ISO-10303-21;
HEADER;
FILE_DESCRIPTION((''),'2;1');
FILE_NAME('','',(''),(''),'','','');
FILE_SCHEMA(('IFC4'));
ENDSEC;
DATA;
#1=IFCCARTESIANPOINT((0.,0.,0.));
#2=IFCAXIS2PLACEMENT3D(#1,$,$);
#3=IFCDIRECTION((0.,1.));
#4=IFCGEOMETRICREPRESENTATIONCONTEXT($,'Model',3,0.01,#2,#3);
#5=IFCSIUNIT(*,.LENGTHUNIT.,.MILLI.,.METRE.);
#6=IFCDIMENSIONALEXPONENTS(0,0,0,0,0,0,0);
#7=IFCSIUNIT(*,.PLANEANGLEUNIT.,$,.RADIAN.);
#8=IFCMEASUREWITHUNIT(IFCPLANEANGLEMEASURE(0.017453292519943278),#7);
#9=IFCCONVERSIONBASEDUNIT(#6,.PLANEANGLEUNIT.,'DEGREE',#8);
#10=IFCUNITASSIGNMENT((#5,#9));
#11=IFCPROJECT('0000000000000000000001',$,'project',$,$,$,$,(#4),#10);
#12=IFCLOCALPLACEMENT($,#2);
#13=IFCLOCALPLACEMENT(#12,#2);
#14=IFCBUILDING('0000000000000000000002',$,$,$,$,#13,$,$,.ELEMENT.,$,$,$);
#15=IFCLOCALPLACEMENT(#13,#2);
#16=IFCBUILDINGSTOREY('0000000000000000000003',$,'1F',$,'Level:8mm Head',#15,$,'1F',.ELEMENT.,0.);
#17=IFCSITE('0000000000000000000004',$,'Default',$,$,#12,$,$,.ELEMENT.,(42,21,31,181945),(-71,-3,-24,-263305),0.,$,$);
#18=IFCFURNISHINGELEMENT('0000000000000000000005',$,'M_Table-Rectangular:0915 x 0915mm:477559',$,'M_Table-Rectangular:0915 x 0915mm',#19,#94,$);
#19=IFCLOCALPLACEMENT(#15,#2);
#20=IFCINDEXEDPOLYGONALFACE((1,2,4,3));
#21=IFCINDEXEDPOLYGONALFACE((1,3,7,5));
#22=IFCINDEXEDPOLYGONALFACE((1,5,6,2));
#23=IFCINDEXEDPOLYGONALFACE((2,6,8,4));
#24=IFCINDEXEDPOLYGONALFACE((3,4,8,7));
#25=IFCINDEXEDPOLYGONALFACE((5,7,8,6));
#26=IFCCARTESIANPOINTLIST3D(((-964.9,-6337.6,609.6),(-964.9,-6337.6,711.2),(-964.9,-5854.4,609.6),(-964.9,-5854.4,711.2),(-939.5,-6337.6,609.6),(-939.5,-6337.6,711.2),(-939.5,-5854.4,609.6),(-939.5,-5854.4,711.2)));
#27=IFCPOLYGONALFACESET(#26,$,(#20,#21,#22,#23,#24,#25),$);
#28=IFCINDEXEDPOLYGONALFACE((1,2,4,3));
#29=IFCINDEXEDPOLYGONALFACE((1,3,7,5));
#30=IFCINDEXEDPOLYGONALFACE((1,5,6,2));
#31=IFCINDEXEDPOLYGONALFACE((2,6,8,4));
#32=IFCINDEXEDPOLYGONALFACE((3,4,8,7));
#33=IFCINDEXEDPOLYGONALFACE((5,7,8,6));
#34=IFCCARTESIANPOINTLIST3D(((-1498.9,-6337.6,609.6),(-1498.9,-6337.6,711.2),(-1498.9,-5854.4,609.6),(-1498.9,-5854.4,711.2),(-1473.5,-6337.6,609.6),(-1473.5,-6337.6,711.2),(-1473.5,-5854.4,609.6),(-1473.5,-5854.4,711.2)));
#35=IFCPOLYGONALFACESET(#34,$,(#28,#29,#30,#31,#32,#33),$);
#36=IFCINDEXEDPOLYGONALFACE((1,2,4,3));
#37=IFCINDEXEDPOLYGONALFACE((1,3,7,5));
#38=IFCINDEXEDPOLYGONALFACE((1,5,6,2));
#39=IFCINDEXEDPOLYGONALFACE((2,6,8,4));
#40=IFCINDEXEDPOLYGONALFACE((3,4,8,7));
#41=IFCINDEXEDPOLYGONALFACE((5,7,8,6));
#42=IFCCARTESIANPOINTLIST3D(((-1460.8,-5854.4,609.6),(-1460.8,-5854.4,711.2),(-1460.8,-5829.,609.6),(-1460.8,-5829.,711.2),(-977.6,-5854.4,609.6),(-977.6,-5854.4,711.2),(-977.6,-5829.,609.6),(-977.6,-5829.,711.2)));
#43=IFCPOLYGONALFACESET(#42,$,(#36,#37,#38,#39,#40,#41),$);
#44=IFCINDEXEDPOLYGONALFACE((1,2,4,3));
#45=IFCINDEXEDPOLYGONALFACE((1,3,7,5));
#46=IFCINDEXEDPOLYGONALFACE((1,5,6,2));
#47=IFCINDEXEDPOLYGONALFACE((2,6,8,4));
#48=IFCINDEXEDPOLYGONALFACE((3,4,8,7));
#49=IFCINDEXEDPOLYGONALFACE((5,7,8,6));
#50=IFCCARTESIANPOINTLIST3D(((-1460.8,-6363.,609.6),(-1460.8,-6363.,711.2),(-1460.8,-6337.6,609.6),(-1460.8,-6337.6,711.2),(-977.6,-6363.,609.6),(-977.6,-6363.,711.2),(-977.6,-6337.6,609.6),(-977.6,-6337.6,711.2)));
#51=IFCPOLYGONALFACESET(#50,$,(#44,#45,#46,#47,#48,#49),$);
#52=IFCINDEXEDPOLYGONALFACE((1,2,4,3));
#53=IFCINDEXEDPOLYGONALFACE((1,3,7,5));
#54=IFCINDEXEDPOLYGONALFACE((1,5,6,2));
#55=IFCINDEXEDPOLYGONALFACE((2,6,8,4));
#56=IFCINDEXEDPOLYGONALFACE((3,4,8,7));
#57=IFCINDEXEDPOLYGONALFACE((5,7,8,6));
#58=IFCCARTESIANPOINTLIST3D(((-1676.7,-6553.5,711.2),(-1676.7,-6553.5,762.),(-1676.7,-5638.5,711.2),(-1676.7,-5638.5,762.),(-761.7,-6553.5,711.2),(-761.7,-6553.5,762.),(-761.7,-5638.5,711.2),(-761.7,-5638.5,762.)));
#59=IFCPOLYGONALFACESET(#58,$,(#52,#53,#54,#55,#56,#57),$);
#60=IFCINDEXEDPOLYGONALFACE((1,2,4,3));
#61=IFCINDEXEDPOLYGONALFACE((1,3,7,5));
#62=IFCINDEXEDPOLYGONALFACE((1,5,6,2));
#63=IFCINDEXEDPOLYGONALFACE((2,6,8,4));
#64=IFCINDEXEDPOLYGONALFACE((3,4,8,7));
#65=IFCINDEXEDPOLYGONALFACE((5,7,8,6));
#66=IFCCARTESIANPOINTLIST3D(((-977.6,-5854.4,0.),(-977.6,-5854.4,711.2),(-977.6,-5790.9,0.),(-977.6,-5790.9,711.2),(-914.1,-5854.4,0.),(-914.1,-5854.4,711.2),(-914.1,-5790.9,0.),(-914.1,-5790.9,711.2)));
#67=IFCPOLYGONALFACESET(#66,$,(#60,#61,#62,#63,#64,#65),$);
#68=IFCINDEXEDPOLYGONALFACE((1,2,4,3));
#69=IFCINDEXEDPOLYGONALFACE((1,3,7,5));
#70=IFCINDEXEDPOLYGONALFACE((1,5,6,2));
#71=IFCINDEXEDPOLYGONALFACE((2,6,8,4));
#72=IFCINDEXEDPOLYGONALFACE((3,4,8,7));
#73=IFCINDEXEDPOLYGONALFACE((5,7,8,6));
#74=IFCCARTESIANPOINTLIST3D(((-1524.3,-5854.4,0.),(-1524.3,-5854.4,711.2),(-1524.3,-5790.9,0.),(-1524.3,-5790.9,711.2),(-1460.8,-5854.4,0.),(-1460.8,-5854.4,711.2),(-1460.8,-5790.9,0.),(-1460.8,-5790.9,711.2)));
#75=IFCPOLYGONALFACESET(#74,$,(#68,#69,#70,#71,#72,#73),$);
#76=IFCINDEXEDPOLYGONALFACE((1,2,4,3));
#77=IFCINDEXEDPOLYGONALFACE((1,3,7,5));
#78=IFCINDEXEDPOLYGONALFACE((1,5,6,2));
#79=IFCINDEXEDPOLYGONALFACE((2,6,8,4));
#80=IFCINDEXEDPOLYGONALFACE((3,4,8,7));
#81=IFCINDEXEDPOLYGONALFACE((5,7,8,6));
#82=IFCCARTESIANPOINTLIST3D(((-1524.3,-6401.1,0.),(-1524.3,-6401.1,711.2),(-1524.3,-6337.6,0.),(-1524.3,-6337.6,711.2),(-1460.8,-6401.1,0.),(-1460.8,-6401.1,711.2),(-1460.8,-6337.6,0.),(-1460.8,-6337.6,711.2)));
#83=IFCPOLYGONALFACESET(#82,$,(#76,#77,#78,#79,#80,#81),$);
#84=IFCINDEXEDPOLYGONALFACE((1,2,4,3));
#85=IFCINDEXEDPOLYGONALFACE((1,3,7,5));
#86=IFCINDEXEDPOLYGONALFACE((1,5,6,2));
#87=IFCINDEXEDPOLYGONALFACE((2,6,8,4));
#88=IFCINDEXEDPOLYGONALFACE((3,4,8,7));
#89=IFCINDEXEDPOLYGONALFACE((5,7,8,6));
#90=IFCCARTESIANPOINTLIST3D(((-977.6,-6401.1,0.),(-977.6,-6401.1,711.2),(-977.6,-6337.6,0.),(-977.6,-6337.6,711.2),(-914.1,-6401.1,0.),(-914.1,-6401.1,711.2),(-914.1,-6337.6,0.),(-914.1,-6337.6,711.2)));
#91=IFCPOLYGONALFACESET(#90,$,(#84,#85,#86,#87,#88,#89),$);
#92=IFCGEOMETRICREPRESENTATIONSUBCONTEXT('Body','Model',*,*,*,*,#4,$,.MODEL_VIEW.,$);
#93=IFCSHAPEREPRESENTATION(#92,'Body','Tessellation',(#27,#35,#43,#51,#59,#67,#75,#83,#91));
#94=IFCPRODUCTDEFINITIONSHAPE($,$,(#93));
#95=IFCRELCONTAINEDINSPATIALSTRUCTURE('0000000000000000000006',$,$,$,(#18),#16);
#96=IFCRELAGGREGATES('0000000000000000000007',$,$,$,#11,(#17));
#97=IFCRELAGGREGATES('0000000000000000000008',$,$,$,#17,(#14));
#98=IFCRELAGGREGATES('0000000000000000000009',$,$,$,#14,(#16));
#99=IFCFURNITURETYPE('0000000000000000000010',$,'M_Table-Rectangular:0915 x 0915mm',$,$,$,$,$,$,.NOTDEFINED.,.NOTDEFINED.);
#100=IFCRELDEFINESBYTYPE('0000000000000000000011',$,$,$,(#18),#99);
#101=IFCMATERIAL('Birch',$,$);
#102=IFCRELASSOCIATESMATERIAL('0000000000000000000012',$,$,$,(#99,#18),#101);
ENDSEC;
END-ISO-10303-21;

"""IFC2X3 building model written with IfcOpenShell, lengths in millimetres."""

from ifc_helpers import new_model, entity, si_unit, converted_unit, direction, frame, frame_2d, origin, origin_2d_with_axis, place, context, subcontext, project, spatial, rectangle, extrude, source, transform, mapped, material, type_object, type_shapes, element, save


model = new_model("IFC2X3")

# Units and contexts
model_context = context("Model", 3, precision=0.01, world=origin(), true_north=direction((0.0, 1.0)))
body_context = subcontext(model_context, "Body", "Model", "MODEL_VIEW")
ifc_project = project(units=[si_unit("LENGTHUNIT", "METRE", prefix="MILLI"), converted_unit("PLANEANGLEUNIT", "DEGREE", entity("IfcPlaneAngleMeasure", 0.017453292519943278), si_unit("PLANEANGLEUNIT", "RADIAN"), dimensions=[0, 0, 0, 0, 0, 0, 0])], contexts=[model_context])

# Site, building, storey
site_placement = place(None, origin())
site = spatial("IfcSite", under=ifc_project, at=site_placement, Name="Default", CompositionType="ELEMENT", RefLatitude=(42, 21, 31, 181945), RefLongitude=(-71, -3, -24, -263305), RefElevation=0.0)
building_placement = place(site_placement, origin())
building = spatial("IfcBuilding", under=site, at=building_placement, CompositionType="ELEMENT")
storey_placement = place(building_placement, origin())
storey = spatial("IfcBuildingStorey", under=building, at=storey_placement, Name="1F", ObjectType="Level:8mm Head", LongName="1F", CompositionType="ELEMENT", Elevation=0.0)

# Furnishing element
ifc_material_1 = material(Name="Birch")
furniture_type_1 = type_object("IfcFurnitureType", Name="M_Table-Rectangular:0915 x 0915mm", AssemblyPlace="NOTDEFINED", material=ifc_material_1)
shared_shape_1 = source(origin(), body_context, "Body", "SweptSolid", [
    extrude(rectangle(XDim=25.4, YDim=483.2, at=origin_2d_with_axis()), frame((267.0, 0.0, 609.6)), (0.0, 0.0, 1.0), 101.6),
    extrude(rectangle(XDim=483.2, YDim=25.4, at=origin_2d_with_axis()), frame((-267.0, 0.0, 609.6), z_axis=(0.0, 0.0, 1.0), x_axis=(0.0, 1.0, 0.0)), (0.0, 0.0, 1.0), 101.6),
    extrude(rectangle(XDim=483.2, YDim=25.4, at=frame_2d((0.0, 0.0), x_axis=(1.0, 0.0))), frame((0.0, 254.3, 609.6), z_axis=(0.0, 0.0, 1.0), x_axis=(-1.0, 0.0, 0.0)), (0.0, 0.0, 1.0), 101.6),
    extrude(rectangle(XDim=25.4, YDim=483.2, at=origin_2d_with_axis()), frame((0.0, -254.3, 609.6), z_axis=(0.0, 0.0, 1.0), x_axis=(0.0, 1.0, 0.0)), (0.0, 0.0, 1.0), 101.6),
    extrude(rectangle(XDim=915.0, YDim=915.0, at=origin_2d_with_axis()), frame((0.0, 0.0, 711.2), z_axis=(0.0, 0.0, 1.0), x_axis=(-1.0, 0.0, 0.0)), (0.0, 0.0, 1.0), 50.8),
    extrude(rectangle(XDim=63.5, YDim=63.5, at=origin_2d_with_axis()), frame((273.3, 273.4, 0.0), z_axis=(0.0, 0.0, 1.0), x_axis=(0.0, -1.0, 0.0)), (0.0, 0.0, 1.0), 711.2),
    extrude(rectangle(XDim=63.5, YDim=63.5, at=origin_2d_with_axis()), frame((-273.3, 273.4, 0.0), z_axis=(0.0, 0.0, 1.0), x_axis=(-1.0, 0.0, 0.0)), (0.0, 0.0, 1.0), 711.2),
    extrude(rectangle(XDim=63.5, YDim=63.5, at=origin_2d_with_axis()), frame((-273.3, -273.4, 0.0), z_axis=(0.0, 0.0, 1.0), x_axis=(0.0, 1.0, 0.0)), (0.0, 0.0, 1.0), 711.2),
    extrude(rectangle(XDim=63.5, YDim=63.5, at=origin_2d_with_axis()), frame((273.3, -273.4, 0.0)), (0.0, 0.0, 1.0), 711.2),
])
type_shapes(furniture_type_1, [shared_shape_1])
for number, where, name in (
    (1, (-1219.2, -6096.0, 0.0), "M_Table-Rectangular:0915 x 0915mm:477559"),
):
    element("IfcFurnishingElement", number, at=place(storey_placement, frame(where)), inside=storey, type_object=furniture_type_1, material=ifc_material_1, Name=name, ObjectType="M_Table-Rectangular:0915 x 0915mm", context=body_context, shape_type="MappedRepresentation", body=[
        mapped(shared_shape_1, transform((0.0, 0.0, 0.0), scale=1.0)),
    ])

save(model, "model.ifc")
